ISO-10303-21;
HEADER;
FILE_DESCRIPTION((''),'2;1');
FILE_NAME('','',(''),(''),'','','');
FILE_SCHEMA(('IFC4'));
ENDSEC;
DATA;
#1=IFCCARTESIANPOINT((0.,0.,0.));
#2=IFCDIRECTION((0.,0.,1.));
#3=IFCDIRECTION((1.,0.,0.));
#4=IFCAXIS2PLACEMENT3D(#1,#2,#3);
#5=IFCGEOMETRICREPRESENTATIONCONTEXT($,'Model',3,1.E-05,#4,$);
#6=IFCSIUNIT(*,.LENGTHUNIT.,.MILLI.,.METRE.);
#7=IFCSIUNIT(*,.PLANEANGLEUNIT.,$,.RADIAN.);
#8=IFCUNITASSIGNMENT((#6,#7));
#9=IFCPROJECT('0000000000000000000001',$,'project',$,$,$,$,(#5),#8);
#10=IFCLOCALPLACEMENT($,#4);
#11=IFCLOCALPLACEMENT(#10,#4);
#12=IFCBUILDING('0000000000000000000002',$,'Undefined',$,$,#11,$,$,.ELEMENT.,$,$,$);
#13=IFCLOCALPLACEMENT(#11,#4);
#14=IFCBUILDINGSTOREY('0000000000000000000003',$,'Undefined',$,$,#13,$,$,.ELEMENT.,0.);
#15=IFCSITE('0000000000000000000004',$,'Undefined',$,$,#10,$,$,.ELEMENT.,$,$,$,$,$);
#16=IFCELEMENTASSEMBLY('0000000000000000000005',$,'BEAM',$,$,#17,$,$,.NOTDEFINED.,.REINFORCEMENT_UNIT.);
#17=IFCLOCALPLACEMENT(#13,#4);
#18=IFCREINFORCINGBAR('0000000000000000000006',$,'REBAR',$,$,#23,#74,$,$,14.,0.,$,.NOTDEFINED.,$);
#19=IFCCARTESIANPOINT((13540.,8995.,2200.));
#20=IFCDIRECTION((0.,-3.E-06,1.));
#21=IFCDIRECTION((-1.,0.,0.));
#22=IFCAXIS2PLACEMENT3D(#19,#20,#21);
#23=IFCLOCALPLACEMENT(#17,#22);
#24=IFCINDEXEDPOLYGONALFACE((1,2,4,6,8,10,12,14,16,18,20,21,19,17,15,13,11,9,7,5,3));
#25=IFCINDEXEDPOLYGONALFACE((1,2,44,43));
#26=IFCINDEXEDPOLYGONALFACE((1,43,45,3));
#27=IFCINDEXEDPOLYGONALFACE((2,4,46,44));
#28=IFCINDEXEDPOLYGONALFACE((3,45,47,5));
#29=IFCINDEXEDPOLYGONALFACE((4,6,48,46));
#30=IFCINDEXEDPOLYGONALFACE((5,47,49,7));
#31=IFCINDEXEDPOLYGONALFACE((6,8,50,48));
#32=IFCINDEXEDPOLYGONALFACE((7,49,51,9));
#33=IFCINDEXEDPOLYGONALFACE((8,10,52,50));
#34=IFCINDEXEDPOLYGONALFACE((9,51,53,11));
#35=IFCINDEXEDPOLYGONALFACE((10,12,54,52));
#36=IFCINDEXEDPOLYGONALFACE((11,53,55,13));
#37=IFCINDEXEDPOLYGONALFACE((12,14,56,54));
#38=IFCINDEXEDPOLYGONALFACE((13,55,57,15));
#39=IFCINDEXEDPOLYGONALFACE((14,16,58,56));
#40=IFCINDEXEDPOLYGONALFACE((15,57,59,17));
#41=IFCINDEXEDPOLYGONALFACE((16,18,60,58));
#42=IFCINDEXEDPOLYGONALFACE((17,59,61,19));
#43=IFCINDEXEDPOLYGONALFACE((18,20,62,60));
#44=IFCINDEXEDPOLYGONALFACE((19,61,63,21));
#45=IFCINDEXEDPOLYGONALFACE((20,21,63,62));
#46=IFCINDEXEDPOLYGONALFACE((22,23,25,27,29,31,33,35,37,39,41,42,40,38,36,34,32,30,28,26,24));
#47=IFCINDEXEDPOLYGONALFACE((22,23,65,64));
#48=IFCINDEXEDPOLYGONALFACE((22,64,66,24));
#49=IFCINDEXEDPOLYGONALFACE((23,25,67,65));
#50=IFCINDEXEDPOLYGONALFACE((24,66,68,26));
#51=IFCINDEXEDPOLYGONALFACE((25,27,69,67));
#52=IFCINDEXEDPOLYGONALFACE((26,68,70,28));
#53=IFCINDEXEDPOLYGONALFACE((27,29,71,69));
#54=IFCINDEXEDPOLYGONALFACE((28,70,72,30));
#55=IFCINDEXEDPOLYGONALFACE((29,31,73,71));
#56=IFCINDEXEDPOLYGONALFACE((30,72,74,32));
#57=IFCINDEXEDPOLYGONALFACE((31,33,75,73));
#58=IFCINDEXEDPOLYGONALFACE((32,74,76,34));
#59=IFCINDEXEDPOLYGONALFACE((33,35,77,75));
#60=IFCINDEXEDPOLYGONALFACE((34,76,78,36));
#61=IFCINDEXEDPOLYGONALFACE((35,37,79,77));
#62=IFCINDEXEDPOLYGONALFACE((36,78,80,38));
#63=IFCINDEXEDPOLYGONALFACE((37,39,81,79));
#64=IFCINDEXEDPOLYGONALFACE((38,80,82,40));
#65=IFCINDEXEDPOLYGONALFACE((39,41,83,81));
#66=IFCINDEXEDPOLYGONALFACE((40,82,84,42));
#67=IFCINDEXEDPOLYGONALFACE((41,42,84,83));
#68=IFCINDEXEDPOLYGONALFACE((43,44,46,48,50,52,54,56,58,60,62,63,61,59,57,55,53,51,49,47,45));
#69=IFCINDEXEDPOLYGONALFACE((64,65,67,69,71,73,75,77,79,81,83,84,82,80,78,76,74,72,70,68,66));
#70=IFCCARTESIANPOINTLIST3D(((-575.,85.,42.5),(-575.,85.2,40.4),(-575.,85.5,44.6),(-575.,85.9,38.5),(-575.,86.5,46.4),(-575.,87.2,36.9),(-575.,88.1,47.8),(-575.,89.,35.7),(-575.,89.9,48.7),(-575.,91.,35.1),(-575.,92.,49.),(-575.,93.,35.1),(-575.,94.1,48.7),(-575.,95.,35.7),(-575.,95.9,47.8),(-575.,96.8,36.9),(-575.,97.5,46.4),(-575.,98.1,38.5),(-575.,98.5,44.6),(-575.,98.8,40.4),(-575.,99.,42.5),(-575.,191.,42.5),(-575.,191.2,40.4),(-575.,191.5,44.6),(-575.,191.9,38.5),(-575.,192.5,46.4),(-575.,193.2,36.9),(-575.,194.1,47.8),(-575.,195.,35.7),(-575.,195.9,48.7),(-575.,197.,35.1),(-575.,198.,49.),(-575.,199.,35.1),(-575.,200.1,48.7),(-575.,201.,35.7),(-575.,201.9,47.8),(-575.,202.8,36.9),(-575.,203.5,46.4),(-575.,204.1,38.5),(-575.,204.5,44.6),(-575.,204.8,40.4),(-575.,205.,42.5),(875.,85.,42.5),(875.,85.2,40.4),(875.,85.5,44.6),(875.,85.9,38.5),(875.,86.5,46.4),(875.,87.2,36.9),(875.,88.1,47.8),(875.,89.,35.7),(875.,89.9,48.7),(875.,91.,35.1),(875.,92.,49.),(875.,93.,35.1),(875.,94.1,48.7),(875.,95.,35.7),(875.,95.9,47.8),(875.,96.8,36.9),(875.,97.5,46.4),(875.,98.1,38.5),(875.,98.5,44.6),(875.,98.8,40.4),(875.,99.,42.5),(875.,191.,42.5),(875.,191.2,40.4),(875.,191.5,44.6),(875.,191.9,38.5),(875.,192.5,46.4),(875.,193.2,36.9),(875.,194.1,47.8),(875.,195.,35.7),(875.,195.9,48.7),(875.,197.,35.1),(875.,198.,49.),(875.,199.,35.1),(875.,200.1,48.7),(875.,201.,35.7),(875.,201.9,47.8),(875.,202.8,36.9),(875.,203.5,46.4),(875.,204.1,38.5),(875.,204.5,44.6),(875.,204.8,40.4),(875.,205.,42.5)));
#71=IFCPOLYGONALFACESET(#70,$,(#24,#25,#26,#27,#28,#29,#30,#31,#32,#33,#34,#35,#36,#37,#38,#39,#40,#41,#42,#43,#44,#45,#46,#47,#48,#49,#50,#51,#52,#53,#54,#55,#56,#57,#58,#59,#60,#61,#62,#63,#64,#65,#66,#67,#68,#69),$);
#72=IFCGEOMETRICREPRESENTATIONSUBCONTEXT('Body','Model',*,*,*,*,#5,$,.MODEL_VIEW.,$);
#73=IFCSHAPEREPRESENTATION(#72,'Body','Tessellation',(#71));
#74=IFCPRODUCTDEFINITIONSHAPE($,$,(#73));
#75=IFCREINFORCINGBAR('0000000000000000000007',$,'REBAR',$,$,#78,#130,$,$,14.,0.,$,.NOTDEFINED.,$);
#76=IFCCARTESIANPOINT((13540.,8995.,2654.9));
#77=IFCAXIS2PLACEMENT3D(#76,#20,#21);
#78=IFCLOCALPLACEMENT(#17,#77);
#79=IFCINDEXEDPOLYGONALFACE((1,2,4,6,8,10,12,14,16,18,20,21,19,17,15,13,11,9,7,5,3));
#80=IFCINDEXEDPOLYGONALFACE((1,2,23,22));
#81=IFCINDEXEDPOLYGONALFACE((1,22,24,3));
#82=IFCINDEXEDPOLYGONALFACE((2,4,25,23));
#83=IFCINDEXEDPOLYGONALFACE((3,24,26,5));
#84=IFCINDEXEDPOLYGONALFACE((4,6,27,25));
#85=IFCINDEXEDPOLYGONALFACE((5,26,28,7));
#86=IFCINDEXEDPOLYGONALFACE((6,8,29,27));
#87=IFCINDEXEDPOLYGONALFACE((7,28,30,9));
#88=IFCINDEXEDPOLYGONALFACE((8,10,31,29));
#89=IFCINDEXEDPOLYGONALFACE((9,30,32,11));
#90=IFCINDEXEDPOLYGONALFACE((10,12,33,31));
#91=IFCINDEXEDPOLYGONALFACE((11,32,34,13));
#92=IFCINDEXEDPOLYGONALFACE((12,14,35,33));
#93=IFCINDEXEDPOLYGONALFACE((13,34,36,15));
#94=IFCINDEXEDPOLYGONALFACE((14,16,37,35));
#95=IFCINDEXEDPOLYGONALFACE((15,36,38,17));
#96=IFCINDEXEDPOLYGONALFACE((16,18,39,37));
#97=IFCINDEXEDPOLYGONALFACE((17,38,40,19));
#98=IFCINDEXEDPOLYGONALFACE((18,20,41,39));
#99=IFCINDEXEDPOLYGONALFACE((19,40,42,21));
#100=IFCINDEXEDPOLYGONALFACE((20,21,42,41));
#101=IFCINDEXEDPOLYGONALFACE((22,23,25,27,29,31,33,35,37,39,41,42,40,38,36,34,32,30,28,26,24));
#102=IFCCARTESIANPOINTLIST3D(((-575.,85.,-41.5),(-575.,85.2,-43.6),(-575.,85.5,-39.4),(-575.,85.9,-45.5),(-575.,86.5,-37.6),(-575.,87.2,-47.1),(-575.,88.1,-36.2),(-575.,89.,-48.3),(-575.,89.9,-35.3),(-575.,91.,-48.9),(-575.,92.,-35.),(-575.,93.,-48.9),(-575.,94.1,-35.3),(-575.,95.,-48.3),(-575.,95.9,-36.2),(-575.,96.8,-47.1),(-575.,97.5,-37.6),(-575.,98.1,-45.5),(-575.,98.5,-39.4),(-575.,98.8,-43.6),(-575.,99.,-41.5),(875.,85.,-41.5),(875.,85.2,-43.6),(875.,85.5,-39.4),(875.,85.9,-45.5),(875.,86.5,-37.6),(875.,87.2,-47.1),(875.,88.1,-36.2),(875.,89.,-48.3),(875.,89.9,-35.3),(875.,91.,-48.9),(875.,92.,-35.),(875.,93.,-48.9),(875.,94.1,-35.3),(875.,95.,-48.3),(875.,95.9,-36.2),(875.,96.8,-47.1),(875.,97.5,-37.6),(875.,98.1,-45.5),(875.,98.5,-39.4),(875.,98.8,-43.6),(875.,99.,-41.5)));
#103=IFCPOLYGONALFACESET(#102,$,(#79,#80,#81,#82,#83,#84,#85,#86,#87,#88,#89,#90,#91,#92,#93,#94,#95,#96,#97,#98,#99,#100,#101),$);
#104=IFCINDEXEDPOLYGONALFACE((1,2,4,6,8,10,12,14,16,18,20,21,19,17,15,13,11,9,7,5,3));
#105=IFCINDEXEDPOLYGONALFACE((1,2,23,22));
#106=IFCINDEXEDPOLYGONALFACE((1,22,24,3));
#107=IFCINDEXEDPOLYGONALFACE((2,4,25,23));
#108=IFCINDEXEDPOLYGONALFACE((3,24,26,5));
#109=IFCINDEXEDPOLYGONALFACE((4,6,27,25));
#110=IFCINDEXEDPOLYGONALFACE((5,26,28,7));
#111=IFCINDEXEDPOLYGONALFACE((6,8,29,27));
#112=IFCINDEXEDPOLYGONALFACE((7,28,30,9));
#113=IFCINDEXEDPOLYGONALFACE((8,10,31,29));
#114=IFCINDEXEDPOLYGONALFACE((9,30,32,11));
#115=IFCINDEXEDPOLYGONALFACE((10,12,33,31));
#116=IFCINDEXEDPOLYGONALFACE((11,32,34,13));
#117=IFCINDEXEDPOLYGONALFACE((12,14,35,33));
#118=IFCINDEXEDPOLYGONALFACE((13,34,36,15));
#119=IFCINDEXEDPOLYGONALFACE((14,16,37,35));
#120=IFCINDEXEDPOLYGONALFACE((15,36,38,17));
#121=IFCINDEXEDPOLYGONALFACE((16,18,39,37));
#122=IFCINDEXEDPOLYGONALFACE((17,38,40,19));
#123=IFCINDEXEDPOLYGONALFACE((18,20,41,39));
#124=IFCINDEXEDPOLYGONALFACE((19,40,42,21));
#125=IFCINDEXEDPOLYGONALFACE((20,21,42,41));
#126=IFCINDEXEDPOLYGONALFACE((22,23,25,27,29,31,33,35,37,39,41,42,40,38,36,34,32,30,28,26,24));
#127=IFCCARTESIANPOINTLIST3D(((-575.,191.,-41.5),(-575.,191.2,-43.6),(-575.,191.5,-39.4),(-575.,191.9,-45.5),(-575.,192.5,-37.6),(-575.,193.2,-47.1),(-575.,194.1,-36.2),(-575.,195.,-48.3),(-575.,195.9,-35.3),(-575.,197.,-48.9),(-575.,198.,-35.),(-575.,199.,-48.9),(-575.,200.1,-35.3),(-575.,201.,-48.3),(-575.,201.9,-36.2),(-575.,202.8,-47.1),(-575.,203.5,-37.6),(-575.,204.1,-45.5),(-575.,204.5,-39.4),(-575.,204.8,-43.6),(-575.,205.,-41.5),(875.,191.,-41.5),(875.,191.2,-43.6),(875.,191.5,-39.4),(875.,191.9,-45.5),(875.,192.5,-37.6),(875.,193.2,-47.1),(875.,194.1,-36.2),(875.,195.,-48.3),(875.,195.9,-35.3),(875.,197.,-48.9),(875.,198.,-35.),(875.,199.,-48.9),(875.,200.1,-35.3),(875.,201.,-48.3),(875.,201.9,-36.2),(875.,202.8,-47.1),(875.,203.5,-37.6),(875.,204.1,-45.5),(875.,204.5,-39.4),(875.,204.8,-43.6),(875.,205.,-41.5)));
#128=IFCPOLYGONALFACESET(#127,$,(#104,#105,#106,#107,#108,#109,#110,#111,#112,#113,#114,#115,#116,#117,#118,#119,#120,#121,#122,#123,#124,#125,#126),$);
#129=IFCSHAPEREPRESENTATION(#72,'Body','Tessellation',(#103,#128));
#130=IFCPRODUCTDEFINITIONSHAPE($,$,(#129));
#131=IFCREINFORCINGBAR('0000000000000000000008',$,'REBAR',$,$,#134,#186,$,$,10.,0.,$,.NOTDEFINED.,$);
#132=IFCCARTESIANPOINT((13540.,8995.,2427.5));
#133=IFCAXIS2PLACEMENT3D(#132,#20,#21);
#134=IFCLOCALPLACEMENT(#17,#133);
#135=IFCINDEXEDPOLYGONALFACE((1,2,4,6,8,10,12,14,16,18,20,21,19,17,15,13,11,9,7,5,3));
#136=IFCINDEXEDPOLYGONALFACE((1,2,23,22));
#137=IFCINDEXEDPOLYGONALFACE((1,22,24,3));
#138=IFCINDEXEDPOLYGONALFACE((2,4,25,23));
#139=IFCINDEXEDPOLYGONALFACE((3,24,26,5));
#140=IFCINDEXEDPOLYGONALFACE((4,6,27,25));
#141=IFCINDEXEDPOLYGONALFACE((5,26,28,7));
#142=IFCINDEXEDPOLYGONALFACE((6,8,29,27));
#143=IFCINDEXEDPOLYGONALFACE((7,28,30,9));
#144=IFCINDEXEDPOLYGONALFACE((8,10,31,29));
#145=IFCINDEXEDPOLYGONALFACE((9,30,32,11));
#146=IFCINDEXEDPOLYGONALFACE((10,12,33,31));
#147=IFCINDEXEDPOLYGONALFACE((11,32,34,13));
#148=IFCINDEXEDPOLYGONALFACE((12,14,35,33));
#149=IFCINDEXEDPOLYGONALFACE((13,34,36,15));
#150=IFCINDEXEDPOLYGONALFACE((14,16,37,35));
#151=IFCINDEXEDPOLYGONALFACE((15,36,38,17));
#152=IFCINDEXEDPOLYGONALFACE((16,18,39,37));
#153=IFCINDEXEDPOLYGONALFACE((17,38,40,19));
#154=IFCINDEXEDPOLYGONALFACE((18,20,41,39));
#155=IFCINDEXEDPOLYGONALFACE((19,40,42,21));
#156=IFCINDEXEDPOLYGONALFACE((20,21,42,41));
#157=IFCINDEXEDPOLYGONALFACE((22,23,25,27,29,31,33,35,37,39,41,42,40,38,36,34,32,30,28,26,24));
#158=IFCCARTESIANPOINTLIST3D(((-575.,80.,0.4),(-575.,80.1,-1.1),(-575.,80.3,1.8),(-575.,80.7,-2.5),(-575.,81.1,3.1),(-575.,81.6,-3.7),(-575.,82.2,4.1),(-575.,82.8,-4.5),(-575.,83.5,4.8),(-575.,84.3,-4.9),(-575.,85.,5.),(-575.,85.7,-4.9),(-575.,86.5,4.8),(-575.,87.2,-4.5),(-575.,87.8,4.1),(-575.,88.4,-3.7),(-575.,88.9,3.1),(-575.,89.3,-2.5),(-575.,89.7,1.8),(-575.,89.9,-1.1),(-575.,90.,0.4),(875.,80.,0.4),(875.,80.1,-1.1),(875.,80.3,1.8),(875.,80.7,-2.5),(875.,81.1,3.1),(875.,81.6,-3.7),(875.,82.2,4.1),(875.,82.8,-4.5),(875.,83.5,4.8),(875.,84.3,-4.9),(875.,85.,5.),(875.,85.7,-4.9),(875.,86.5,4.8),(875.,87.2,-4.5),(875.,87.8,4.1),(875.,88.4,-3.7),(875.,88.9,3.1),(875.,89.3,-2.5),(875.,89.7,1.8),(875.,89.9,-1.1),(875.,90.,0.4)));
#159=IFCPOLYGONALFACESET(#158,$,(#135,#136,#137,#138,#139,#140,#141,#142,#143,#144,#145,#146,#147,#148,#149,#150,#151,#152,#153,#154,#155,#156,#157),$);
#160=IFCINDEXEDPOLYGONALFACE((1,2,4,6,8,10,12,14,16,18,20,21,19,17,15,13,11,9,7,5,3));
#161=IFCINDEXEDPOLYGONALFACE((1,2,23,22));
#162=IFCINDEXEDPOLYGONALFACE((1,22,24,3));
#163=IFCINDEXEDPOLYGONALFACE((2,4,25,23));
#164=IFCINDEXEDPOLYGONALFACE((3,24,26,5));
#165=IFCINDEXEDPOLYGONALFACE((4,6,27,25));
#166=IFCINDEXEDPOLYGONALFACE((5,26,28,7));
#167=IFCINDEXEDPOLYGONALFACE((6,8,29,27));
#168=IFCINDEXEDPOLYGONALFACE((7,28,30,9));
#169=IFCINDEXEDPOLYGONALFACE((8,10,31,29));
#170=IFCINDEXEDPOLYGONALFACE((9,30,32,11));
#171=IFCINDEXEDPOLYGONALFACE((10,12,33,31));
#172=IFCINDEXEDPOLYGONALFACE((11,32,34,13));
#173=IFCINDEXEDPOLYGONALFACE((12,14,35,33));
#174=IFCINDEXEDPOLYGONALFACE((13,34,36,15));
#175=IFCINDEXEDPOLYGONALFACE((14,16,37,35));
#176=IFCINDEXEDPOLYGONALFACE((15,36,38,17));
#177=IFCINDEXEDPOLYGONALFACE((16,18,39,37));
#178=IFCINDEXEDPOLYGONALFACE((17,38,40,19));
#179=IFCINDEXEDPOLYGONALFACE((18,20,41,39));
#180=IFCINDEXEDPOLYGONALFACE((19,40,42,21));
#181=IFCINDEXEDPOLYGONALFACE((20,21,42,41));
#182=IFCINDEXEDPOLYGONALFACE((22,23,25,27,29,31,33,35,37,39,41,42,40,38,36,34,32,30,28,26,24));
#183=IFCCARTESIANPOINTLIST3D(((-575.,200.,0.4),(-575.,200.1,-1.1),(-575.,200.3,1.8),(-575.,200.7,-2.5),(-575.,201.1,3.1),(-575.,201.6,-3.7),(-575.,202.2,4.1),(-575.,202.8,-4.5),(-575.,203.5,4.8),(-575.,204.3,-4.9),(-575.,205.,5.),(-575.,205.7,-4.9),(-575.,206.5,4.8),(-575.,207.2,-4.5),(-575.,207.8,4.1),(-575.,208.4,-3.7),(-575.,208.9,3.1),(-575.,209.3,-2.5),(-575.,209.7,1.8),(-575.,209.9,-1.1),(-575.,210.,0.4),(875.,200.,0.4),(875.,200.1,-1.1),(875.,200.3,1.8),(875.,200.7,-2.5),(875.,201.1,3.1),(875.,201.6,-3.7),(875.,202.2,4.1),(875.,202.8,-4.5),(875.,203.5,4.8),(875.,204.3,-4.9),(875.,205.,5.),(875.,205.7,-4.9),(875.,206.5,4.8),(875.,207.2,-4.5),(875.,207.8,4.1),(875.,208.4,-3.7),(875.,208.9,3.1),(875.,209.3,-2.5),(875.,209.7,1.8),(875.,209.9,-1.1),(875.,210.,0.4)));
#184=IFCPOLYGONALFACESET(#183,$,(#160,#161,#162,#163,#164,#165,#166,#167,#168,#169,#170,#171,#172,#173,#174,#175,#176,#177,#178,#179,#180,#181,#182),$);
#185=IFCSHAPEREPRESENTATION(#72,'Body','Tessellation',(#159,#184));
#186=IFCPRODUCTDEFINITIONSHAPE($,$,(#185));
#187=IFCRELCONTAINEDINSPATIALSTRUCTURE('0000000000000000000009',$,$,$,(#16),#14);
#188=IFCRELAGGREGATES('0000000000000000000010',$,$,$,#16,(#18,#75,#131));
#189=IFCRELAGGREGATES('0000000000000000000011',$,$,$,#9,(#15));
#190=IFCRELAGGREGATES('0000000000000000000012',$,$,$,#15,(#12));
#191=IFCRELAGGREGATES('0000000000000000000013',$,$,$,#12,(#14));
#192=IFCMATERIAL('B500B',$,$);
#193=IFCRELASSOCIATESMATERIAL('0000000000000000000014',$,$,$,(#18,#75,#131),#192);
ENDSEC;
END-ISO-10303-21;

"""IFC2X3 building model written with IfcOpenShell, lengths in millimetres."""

from ifc_helpers import new_model, entity, si_unit, frame, origin_with_axes, place, context, subcontext, project, spatial, source, transform, mapped, material, element, aggregate, save


model = new_model("IFC2X3")

# Units and contexts
model_context = context("Model", 3, precision=1e-05, world=origin_with_axes())
body_context = subcontext(model_context, "Body", "Model", "MODEL_VIEW")
ifc_project = project(units=[si_unit("LENGTHUNIT", "METRE", prefix="MILLI"), si_unit("PLANEANGLEUNIT", "RADIAN")], contexts=[model_context])

# Site, building, storey
site_placement = place(None, origin_with_axes())
site = spatial("IfcSite", under=ifc_project, at=site_placement, Name="Undefined", CompositionType="ELEMENT")
building_placement = place(site_placement, origin_with_axes())
building = spatial("IfcBuilding", under=site, at=building_placement, Name="Undefined", CompositionType="ELEMENT")
storey_placement = place(building_placement, origin_with_axes())
storey = spatial("IfcBuildingStorey", under=building, at=storey_placement, Name="Undefined", CompositionType="ELEMENT", Elevation=0.0)

# Shared definitions
ifc_material_1 = material(Name="B500B")

# Element assembly, reinforcing bars
assembly_1_placement = place(storey_placement, origin_with_axes())
assembly_1 = element("IfcElementAssembly", 1, at=assembly_1_placement, inside=storey, Name="BEAM", AssemblyPlace="NOTDEFINED", PredefinedType="REINFORCEMENT_UNIT")
shared_shape_1 = source(origin_with_axes(), body_context, "Body", "AdvancedSweptSolid", [
    entity("IfcSweptDiskSolid", entity("IfcTrimmedCurve", entity("IfcLine", entity("IfcCartesianPoint", [0.0, 0.0, 0.0]), entity("IfcVector", entity("IfcDirection", [1.0, 0.0, 0.0]), 1.0)), [entity("IfcParameterValue", 0.0)], [entity("IfcParameterValue", 1449.999613)], True, "PARAMETER"), 7.0, None, 0.0, 1450.0),
])
shared_shape_2 = source(origin_with_axes(), body_context, "Body", "AdvancedSweptSolid", [
    entity("IfcSweptDiskSolid", entity("IfcTrimmedCurve", entity("IfcLine", entity("IfcCartesianPoint", [0.0, 0.0, 0.0]), entity("IfcVector", entity("IfcDirection", [1.0, 0.0, 0.0]), 1.0)), [entity("IfcParameterValue", 0.0)], [entity("IfcParameterValue", 1449.999613)], True, "PARAMETER"), 7.0, None, 0.0, 1450.0),
])
reinforcing_bar_1_placement = place(assembly_1_placement, frame((13540.0, 8995.0, 2200.0), z_axis=(0.0, -0.000003, 1.0), x_axis=(-1.0, 0.0, 0.0)))
reinforcing_bar_1 = element("IfcReinforcingBar", 2, at=reinforcing_bar_1_placement, material=ifc_material_1, Name="REBAR", BarRole="NOTDEFINED", CrossSectionArea=0.0, NominalDiameter=14.0, context=body_context, shape_type="MappedRepresentation", body=[
    mapped(shared_shape_1, transform((-575.0, 92.0, 42.0))),
    mapped(shared_shape_2, transform((-575.0, 198.0, 42.0))),
])
shared_shape_3 = source(origin_with_axes(), body_context, "Body", "AdvancedSweptSolid", [
    entity("IfcSweptDiskSolid", entity("IfcTrimmedCurve", entity("IfcLine", entity("IfcCartesianPoint", [0.0, 0.0, 0.0]), entity("IfcVector", entity("IfcDirection", [1.0, 0.0, 0.0]), 1.0)), [entity("IfcParameterValue", 0.0)], [entity("IfcParameterValue", 1449.999613)], True, "PARAMETER"), 7.0, None, 0.0, 1450.0),
])
shared_shape_4 = source(origin_with_axes(), body_context, "Body", "AdvancedSweptSolid", [
    entity("IfcSweptDiskSolid", entity("IfcTrimmedCurve", entity("IfcLine", entity("IfcCartesianPoint", [0.0, 0.0, 0.0]), entity("IfcVector", entity("IfcDirection", [1.0, 0.0, 0.0]), 1.0)), [entity("IfcParameterValue", 0.0)], [entity("IfcParameterValue", 1449.999613)], True, "PARAMETER"), 7.0, None, 0.0, 1450.0),
])
reinforcing_bar_2_placement = place(assembly_1_placement, frame((13540.0, 8995.0, 2654.9), z_axis=(0.0, -0.000003, 1.0), x_axis=(-1.0, 0.0, 0.0)))
reinforcing_bar_2 = element("IfcReinforcingBar", 3, at=reinforcing_bar_2_placement, material=ifc_material_1, Name="REBAR", BarRole="NOTDEFINED", CrossSectionArea=0.0, NominalDiameter=14.0, context=body_context, shape_type="MappedRepresentation", body=[
    mapped(shared_shape_3, transform((-575.0, 92.0, -42.0))),
    mapped(shared_shape_4, transform((-575.0, 198.0, -42.0))),
])
shared_shape_5 = source(origin_with_axes(), body_context, "Body", "AdvancedSweptSolid", [
    entity("IfcSweptDiskSolid", entity("IfcTrimmedCurve", entity("IfcLine", entity("IfcCartesianPoint", [0.0, 0.0, 0.0]), entity("IfcVector", entity("IfcDirection", [1.0, 0.0, 0.0]), 1.0)), [entity("IfcParameterValue", 0.0)], [entity("IfcParameterValue", 1449.999613)], True, "PARAMETER"), 5.0, None, 0.0, 1450.0),
])
shared_shape_6 = source(origin_with_axes(), body_context, "Body", "AdvancedSweptSolid", [
    entity("IfcSweptDiskSolid", entity("IfcTrimmedCurve", entity("IfcLine", entity("IfcCartesianPoint", [0.0, 0.0, 0.0]), entity("IfcVector", entity("IfcDirection", [1.0, 0.0, 0.0]), 1.0)), [entity("IfcParameterValue", 0.0)], [entity("IfcParameterValue", 1449.999613)], True, "PARAMETER"), 5.0, None, 0.0, 1450.0),
])
reinforcing_bar_3_placement = place(assembly_1_placement, frame((13540.0, 8995.0, 2427.5), z_axis=(0.0, -0.000003, 1.0), x_axis=(-1.0, 0.0, 0.0)))
reinforcing_bar_3 = element("IfcReinforcingBar", 4, at=reinforcing_bar_3_placement, material=ifc_material_1, Name="REBAR", BarRole="NOTDEFINED", CrossSectionArea=0.0, NominalDiameter=10.0, context=body_context, shape_type="MappedRepresentation", body=[
    mapped(shared_shape_5, transform((-575.0, 85.0, 0.0))),
    mapped(shared_shape_6, transform((-575.0, 205.0, 0.0))),
])
aggregate(assembly_1, [reinforcing_bar_1, reinforcing_bar_2, reinforcing_bar_3])

save(model, "model.ifc")
